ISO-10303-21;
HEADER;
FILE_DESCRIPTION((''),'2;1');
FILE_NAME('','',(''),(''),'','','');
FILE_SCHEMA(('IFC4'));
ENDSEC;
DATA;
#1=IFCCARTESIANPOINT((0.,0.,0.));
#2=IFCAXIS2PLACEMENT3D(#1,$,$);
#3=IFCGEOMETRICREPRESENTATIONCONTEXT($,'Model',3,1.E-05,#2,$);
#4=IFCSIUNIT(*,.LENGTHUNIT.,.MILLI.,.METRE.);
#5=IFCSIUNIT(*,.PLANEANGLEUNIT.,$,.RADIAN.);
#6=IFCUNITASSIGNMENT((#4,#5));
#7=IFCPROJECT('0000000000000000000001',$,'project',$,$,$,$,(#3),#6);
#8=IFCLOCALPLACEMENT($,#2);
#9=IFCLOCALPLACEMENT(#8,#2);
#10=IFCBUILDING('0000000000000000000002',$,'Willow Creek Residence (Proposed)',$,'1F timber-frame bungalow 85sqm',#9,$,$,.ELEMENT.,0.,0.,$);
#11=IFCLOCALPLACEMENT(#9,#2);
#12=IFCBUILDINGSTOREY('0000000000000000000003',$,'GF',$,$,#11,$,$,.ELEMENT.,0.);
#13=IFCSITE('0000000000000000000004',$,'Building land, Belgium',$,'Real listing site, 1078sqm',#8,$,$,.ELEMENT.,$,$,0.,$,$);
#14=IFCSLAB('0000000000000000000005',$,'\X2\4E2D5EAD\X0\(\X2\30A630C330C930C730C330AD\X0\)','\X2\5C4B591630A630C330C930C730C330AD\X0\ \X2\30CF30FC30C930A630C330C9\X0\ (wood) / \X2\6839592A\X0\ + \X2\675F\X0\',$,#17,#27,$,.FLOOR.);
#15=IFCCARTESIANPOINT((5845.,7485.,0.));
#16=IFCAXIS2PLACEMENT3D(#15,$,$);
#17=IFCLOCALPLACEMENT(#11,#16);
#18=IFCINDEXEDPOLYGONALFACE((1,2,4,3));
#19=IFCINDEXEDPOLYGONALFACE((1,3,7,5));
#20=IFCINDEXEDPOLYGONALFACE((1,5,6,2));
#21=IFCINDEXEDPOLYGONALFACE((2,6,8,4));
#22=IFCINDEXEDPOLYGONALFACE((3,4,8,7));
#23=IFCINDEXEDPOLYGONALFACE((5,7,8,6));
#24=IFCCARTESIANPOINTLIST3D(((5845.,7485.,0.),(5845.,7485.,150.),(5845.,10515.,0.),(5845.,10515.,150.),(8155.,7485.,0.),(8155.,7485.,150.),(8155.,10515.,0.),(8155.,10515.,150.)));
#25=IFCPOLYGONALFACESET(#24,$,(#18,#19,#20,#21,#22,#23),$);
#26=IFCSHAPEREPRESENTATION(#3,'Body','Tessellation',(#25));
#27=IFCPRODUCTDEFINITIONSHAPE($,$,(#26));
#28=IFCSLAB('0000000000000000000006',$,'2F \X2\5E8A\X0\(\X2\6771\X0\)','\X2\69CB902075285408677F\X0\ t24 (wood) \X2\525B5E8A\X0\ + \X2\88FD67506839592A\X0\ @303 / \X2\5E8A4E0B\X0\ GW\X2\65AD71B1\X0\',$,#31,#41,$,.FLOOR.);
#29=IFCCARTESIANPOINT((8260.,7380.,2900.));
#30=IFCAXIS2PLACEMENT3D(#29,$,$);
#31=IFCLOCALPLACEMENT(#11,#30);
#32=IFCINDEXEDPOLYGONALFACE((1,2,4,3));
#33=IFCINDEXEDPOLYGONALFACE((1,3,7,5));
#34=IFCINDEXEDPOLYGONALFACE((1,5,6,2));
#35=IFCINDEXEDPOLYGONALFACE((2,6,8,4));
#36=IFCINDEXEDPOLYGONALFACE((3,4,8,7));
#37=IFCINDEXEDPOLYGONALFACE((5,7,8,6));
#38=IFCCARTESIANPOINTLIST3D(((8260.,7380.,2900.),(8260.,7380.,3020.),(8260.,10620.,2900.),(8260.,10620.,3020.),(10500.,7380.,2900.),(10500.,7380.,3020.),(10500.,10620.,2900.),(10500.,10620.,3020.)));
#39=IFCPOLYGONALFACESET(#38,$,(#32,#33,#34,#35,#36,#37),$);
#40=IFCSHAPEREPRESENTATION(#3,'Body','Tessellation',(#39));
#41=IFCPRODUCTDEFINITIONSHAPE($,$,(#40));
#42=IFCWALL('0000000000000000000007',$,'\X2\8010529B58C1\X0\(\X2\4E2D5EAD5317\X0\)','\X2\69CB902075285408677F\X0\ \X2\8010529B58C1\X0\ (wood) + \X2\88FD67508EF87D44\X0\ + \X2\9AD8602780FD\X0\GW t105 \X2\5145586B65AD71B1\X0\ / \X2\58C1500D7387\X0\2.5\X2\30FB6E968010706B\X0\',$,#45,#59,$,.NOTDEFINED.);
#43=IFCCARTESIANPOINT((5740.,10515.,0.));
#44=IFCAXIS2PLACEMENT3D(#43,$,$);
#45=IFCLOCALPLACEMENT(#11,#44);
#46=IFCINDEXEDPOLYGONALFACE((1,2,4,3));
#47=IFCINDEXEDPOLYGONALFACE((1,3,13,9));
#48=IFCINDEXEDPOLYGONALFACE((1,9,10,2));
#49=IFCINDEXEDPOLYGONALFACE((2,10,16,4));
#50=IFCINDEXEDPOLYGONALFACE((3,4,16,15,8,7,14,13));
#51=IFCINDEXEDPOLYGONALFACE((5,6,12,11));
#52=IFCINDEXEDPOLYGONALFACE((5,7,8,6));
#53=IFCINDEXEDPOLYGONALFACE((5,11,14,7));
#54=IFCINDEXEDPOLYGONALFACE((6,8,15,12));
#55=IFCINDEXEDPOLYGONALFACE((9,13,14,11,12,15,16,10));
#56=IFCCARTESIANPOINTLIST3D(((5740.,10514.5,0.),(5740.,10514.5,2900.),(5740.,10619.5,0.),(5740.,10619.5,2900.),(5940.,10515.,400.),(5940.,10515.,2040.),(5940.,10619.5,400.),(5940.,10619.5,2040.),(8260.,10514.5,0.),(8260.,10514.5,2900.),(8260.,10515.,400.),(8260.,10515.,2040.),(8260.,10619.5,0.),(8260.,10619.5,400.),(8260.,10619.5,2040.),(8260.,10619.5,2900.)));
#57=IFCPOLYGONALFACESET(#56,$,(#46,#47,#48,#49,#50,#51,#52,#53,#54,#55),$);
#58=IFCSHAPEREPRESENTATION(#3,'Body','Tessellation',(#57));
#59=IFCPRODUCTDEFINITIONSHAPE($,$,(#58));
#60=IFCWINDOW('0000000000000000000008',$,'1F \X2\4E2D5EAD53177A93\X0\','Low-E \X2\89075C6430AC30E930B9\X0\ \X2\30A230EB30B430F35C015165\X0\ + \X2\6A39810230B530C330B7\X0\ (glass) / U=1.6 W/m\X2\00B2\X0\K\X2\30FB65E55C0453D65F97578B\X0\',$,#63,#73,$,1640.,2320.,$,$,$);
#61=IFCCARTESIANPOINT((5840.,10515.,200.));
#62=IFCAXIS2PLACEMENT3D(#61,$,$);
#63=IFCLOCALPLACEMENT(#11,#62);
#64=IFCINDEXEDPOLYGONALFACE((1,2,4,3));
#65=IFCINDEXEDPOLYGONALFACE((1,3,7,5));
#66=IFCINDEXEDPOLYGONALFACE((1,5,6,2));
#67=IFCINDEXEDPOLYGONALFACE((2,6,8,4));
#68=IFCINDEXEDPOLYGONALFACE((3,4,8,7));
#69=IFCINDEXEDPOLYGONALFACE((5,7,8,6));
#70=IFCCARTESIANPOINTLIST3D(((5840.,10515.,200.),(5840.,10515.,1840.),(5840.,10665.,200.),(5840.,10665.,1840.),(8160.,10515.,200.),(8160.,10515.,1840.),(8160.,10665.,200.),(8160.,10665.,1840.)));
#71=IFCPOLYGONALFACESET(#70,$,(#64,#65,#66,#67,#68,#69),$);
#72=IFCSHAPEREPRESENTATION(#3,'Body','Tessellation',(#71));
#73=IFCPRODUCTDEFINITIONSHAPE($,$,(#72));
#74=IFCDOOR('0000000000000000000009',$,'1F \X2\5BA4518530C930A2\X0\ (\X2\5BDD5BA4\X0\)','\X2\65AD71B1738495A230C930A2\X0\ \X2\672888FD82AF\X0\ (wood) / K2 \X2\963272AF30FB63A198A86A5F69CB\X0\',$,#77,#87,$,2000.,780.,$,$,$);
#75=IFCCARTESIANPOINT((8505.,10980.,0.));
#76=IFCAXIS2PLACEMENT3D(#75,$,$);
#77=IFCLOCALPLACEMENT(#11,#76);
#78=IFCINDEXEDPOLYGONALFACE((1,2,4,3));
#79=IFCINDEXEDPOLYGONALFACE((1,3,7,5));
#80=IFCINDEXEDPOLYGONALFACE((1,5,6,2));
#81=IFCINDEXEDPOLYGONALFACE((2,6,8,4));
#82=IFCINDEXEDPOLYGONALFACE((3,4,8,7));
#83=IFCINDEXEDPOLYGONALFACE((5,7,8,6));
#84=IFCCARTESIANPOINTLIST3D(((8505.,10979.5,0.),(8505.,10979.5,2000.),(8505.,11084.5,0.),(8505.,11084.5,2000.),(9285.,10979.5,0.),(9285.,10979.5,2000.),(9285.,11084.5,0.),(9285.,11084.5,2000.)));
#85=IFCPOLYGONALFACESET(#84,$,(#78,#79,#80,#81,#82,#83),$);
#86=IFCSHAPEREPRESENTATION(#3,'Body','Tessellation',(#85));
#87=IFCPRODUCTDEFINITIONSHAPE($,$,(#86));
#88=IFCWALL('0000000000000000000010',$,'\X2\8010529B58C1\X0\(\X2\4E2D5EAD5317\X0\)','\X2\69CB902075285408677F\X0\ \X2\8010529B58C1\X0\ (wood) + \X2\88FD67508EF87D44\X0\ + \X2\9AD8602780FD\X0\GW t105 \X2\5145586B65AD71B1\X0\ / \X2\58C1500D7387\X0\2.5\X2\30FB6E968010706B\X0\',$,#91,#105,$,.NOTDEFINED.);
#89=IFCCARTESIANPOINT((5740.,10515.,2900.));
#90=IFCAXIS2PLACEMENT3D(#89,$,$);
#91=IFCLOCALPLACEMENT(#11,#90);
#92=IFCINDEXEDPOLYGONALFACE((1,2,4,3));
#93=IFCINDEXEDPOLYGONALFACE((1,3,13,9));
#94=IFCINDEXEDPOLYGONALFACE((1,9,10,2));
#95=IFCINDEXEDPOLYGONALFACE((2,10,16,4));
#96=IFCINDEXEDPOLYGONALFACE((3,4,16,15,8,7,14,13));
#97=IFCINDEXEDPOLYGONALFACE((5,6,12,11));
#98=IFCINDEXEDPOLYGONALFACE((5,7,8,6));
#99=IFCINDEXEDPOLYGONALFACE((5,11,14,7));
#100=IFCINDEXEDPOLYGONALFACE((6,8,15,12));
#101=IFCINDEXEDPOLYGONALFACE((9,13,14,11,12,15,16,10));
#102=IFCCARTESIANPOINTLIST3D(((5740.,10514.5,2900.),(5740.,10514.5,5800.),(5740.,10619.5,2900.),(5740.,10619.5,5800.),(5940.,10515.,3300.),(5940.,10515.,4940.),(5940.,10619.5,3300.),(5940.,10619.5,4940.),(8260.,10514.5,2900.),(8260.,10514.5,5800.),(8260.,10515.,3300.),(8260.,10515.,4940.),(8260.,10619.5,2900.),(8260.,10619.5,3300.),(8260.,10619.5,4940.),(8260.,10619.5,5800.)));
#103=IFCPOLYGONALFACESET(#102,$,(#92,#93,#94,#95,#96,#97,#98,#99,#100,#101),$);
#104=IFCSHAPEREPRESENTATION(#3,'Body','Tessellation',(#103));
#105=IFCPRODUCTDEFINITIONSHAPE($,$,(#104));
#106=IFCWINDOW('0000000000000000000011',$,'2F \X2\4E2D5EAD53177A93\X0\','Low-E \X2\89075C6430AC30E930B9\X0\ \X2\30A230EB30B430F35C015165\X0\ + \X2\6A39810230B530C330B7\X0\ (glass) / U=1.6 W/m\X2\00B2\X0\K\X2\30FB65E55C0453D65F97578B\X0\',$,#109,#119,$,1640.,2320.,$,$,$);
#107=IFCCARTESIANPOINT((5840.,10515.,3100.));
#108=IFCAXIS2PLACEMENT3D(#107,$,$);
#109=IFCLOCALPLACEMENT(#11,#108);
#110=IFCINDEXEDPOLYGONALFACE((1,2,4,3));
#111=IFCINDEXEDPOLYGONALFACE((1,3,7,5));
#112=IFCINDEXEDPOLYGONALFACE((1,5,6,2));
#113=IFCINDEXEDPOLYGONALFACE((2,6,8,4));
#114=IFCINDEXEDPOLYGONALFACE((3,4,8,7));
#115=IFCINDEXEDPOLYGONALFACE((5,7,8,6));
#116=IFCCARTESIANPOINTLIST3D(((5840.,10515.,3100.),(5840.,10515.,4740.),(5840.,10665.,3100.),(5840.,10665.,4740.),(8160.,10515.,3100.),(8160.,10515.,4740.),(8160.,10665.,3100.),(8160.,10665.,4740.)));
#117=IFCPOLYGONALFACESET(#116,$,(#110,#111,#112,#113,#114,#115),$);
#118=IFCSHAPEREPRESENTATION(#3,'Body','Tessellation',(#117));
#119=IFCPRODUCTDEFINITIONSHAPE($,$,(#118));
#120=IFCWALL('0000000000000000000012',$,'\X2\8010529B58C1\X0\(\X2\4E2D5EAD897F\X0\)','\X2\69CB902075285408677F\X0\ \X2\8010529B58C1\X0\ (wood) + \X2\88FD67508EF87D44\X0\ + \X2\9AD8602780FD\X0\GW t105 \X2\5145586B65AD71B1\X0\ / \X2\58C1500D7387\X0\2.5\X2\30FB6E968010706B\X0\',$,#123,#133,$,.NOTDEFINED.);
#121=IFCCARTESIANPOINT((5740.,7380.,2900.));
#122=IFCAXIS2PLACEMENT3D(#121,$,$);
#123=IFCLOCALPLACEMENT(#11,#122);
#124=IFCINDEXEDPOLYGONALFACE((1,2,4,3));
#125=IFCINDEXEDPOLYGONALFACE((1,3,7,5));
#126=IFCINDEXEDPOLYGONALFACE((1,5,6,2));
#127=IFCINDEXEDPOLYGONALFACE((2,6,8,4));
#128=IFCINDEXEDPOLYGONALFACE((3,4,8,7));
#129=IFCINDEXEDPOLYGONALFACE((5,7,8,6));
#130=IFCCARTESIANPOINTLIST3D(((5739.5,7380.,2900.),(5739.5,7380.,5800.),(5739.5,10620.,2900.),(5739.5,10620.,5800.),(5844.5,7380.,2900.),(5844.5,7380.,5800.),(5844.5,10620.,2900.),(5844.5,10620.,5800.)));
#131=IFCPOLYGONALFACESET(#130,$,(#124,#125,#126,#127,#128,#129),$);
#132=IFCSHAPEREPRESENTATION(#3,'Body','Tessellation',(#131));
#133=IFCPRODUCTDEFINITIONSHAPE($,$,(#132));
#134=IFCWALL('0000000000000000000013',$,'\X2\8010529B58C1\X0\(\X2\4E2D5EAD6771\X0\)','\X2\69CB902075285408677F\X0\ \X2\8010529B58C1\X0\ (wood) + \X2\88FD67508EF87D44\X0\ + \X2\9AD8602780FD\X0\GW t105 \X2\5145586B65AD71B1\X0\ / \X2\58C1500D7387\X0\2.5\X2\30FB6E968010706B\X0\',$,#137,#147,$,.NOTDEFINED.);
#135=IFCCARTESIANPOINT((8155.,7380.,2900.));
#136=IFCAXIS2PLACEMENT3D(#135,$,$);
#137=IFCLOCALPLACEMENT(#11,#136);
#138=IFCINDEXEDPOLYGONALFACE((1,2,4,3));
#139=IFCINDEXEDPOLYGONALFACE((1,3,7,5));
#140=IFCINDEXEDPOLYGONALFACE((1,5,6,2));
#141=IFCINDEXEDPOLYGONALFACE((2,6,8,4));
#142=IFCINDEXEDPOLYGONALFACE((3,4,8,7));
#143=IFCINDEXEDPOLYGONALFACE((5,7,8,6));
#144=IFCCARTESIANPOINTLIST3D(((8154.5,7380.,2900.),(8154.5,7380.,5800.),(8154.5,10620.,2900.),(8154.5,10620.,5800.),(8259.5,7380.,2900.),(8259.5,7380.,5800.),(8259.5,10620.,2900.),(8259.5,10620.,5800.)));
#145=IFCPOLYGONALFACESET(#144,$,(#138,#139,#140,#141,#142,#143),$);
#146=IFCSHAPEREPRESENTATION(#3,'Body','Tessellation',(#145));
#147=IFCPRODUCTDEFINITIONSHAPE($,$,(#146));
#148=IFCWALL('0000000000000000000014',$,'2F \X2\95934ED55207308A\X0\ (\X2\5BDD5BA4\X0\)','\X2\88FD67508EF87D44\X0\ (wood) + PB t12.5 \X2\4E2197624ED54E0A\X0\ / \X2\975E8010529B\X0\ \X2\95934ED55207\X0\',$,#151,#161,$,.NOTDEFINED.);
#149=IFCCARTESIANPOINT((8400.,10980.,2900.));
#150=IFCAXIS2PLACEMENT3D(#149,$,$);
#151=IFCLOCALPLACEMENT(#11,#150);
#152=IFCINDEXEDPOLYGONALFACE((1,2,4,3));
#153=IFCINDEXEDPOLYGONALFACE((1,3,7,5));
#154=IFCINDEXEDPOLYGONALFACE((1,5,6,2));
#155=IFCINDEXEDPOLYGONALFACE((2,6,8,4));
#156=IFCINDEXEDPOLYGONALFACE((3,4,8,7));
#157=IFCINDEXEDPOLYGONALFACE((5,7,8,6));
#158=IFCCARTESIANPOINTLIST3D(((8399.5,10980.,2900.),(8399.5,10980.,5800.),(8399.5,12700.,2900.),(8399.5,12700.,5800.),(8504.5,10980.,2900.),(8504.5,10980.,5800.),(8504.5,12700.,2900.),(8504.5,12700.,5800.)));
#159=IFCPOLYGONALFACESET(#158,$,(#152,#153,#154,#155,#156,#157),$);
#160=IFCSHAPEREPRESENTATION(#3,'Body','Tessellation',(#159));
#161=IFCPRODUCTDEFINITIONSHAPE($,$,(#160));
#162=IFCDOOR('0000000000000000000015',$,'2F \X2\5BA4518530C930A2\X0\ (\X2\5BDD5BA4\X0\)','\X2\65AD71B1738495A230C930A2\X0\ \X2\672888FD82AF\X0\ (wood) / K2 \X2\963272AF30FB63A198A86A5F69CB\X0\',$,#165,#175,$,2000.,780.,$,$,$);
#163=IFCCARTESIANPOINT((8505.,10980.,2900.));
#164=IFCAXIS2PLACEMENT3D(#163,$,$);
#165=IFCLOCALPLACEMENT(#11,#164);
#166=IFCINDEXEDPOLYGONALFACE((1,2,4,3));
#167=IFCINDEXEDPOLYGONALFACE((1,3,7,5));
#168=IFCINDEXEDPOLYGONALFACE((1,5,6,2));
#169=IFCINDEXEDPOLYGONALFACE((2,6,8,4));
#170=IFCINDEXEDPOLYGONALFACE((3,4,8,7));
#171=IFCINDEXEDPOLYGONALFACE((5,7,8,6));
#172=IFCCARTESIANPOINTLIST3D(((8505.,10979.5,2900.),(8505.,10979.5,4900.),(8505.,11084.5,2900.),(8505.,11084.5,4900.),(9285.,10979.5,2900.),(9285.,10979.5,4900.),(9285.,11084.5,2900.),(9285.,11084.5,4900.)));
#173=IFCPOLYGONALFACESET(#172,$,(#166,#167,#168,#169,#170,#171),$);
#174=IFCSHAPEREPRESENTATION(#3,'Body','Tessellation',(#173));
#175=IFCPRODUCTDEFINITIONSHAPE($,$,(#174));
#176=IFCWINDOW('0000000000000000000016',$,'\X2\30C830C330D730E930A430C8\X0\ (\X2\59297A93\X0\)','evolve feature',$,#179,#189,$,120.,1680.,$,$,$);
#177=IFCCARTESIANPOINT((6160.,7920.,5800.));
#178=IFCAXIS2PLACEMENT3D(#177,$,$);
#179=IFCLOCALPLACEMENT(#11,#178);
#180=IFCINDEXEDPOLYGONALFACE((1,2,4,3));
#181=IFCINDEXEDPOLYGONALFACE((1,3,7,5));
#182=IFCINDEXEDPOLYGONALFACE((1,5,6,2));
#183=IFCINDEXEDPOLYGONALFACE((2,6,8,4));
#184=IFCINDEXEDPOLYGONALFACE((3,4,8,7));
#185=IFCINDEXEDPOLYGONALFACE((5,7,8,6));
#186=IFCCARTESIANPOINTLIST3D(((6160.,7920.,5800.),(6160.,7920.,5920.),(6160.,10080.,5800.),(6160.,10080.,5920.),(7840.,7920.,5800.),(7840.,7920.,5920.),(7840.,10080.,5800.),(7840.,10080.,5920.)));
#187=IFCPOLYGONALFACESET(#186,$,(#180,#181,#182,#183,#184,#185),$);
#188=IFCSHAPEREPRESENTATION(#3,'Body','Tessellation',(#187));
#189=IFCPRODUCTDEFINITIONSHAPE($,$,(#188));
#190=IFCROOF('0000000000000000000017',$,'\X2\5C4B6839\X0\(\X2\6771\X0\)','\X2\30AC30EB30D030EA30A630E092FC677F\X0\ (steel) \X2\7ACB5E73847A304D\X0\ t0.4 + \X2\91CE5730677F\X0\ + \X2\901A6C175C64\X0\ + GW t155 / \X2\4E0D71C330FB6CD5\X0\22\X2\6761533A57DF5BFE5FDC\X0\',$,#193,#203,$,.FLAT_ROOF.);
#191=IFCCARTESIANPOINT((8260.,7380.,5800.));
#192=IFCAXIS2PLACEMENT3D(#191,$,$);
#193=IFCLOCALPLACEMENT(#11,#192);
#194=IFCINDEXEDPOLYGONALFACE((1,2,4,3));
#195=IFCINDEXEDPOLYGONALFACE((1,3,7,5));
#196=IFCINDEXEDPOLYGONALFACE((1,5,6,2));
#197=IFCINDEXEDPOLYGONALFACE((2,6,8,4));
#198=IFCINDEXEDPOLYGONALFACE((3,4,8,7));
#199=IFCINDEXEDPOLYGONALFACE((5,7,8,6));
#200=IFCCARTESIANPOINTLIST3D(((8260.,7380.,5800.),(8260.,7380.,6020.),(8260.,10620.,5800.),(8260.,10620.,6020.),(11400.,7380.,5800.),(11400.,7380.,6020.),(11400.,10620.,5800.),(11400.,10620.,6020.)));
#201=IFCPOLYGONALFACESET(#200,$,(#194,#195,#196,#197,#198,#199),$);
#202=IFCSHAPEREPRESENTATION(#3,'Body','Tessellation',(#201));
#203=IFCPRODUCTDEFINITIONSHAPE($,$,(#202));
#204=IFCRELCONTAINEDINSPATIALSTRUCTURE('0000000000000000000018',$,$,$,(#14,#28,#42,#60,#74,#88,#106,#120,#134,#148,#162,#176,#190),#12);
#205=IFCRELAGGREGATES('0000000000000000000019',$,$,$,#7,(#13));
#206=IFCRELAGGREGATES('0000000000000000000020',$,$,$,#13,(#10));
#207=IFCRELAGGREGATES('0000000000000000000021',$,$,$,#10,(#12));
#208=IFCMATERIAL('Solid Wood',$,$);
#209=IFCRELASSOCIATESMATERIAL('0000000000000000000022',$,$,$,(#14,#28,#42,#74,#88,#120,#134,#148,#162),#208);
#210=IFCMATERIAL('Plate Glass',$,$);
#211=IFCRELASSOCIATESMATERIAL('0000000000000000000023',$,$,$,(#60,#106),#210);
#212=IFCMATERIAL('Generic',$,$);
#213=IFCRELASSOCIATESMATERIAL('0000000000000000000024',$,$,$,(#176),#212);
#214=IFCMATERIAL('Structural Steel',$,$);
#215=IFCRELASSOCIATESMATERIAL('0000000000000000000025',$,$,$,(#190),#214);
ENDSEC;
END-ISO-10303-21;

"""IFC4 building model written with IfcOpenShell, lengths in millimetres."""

from ifc_helpers import new_model, si_unit, frame, frame_2d, origin, place, context, project, spatial, rectangle, extrude, material, element, fill, save


model = new_model("IFC4")

# Units and contexts
model_context = context("Model", 3, precision=1e-05, world=origin())
ifc_project = project(units=[si_unit("LENGTHUNIT", "METRE", prefix="MILLI"), si_unit("PLANEANGLEUNIT", "RADIAN")], contexts=[model_context])

# Site, building, storey
site_placement = place(None, origin())
site = spatial("IfcSite", under=ifc_project, at=site_placement, Name="Building land, Belgium", ObjectType="Real listing site, 1078sqm", CompositionType="ELEMENT", RefElevation=0.0)
building_placement = place(site_placement, origin())
building = spatial("IfcBuilding", under=site, at=building_placement, Name="Willow Creek Residence (Proposed)", ObjectType="1F timber-frame bungalow 85sqm", CompositionType="ELEMENT", ElevationOfRefHeight=0.0, ElevationOfTerrain=0.0)
storey_placement = place(building_placement, origin())
storey = spatial("IfcBuildingStorey", under=building, at=storey_placement, Name="GF", CompositionType="ELEMENT", Elevation=0.0)

# Slabs
ifc_material_1 = material(Name="Solid Wood")
slab_1_placement = place(storey_placement, frame((5845.0, 7485.0, 0.0)))
element("IfcSlab", 1, at=slab_1_placement, inside=storey, material=ifc_material_1, Name="中庭(ウッドデッキ)", Description="屋外ウッドデッキ ハードウッド (wood) / 根太 + 束", PredefinedType="FLOOR", context=model_context, shape_type="SweptSolid", body=[
    extrude(rectangle(XDim=2310.0, YDim=3030.0, at=frame_2d((1155.0, 1515.0))), frame((5845.0, 7485.0, 0.0)), (0.0, 0.0, 1.0), 150.0),
])
slab_2_placement = place(storey_placement, frame((8260.0, 7380.0, 2900.0)))
element("IfcSlab", 2, at=slab_2_placement, inside=storey, material=ifc_material_1, Name="2F 床(東)", Description="構造用合板 t24 (wood) 剛床 + 製材根太 @303 / 床下 GW断熱", PredefinedType="FLOOR", context=model_context, shape_type="SweptSolid", body=[
    extrude(rectangle(XDim=2240.0, YDim=3240.0, at=frame_2d((1120.0, 1620.0))), frame((8260.0, 7380.0, 2900.0)), (0.0, 0.0, 1.0), 120.0),
])

# Wall, opening, window
wall_1_placement = place(storey_placement, frame((5740.0, 10515.0, 0.0)))
wall_1 = element("IfcWall", 3, at=wall_1_placement, inside=storey, material=ifc_material_1, Name="耐力壁(中庭北)", Description="構造用合板 耐力壁 (wood) + 製材軸組 + 高性能GW t105 充填断熱 / 壁倍率2.5・準耐火", PredefinedType="NOTDEFINED", context=model_context, shape_type="SweptSolid", body=[
    extrude(rectangle(XDim=2520.0, YDim=105.0, at=frame_2d((1260.0, 52.0))), frame((5740.0, 10515.0, 0.0)), (0.0, 0.0, 1.0), 2900.0),
])
opening_1_placement = place(storey_placement, frame((5840.0, 10515.0, 200.0)))
opening_1 = element("IfcOpeningElement", 4, at=opening_1_placement, cuts=wall_1, PredefinedType="NOTDEFINED", context=model_context, shape_type="SweptSolid", body=[
    extrude(rectangle(XDim=2320.0, YDim=150.0, at=frame_2d((1160.0, 75.0))), frame((5840.0, 10515.0, 200.0)), (0.0, 0.0, 1.0), 1640.0),
])
ifc_material_2 = material(Name="Plate Glass")
window_1_placement = place(storey_placement, frame((5840.0, 10515.0, 200.0)))
window_1 = element("IfcWindow", 5, at=window_1_placement, inside=storey, material=ifc_material_2, Name="1F 中庭北窓", Description="Low-E 複層ガラス アルゴン封入 + 樹脂サッシ (glass) / U=1.6 W/m²K・日射取得型", OverallHeight=1640.0, OverallWidth=2320.0, context=model_context, shape_type="SweptSolid", body=[
    extrude(rectangle(XDim=2320.0, YDim=150.0, at=frame_2d((1160.0, 75.0))), frame((5840.0, 10515.0, 200.0)), (0.0, 0.0, 1.0), 1640.0),
])
fill(opening_1, window_1)

# Door
door_1_placement = place(storey_placement, frame((8505.0, 10980.0, 0.0)))
element("IfcDoor", 6, at=door_1_placement, inside=storey, material=ifc_material_1, Name="1F 室内ドア (寝室)", Description="断熱玄関ドア 木製芯 (wood) / K2 防犯・採風機構", OverallHeight=2000.0, OverallWidth=780.0, context=model_context, shape_type="SweptSolid", body=[
    extrude(rectangle(XDim=780.0, YDim=105.0, at=frame_2d((390.0, 52.0))), frame((8505.0, 10980.0, 0.0)), (0.0, 0.0, 1.0), 2000.0),
])

# Wall, opening, window
wall_2_placement = place(storey_placement, frame((5740.0, 10515.0, 2900.0)))
wall_2 = element("IfcWall", 7, at=wall_2_placement, inside=storey, material=ifc_material_1, Name="耐力壁(中庭北)", Description="構造用合板 耐力壁 (wood) + 製材軸組 + 高性能GW t105 充填断熱 / 壁倍率2.5・準耐火", PredefinedType="NOTDEFINED", context=model_context, shape_type="SweptSolid", body=[
    extrude(rectangle(XDim=2520.0, YDim=105.0, at=frame_2d((1260.0, 52.0))), frame((5740.0, 10515.0, 2900.0)), (0.0, 0.0, 1.0), 2900.0),
])
opening_2_placement = place(storey_placement, frame((5840.0, 10515.0, 3100.0)))
opening_2 = element("IfcOpeningElement", 8, at=opening_2_placement, cuts=wall_2, PredefinedType="NOTDEFINED", context=model_context, shape_type="SweptSolid", body=[
    extrude(rectangle(XDim=2320.0, YDim=150.0, at=frame_2d((1160.0, 75.0))), frame((5840.0, 10515.0, 3100.0)), (0.0, 0.0, 1.0), 1640.0),
])
window_2_placement = place(storey_placement, frame((5840.0, 10515.0, 3100.0)))
window_2 = element("IfcWindow", 9, at=window_2_placement, inside=storey, material=ifc_material_2, Name="2F 中庭北窓", Description="Low-E 複層ガラス アルゴン封入 + 樹脂サッシ (glass) / U=1.6 W/m²K・日射取得型", OverallHeight=1640.0, OverallWidth=2320.0, context=model_context, shape_type="SweptSolid", body=[
    extrude(rectangle(XDim=2320.0, YDim=150.0, at=frame_2d((1160.0, 75.0))), frame((5840.0, 10515.0, 3100.0)), (0.0, 0.0, 1.0), 1640.0),
])
fill(opening_2, window_2)

# Walls
wall_3_placement = place(storey_placement, frame((5740.0, 7380.0, 2900.0)))
element("IfcWall", 10, at=wall_3_placement, inside=storey, material=ifc_material_1, Name="耐力壁(中庭西)", Description="構造用合板 耐力壁 (wood) + 製材軸組 + 高性能GW t105 充填断熱 / 壁倍率2.5・準耐火", PredefinedType="NOTDEFINED", context=model_context, shape_type="SweptSolid", body=[
    extrude(rectangle(XDim=105.0, YDim=3240.0, at=frame_2d((52.0, 1620.0))), frame((5740.0, 7380.0, 2900.0)), (0.0, 0.0, 1.0), 2900.0),
])
wall_4_placement = place(storey_placement, frame((8155.0, 7380.0, 2900.0)))
element("IfcWall", 11, at=wall_4_placement, inside=storey, material=ifc_material_1, Name="耐力壁(中庭東)", Description="構造用合板 耐力壁 (wood) + 製材軸組 + 高性能GW t105 充填断熱 / 壁倍率2.5・準耐火", PredefinedType="NOTDEFINED", context=model_context, shape_type="SweptSolid", body=[
    extrude(rectangle(XDim=105.0, YDim=3240.0, at=frame_2d((52.0, 1620.0))), frame((8155.0, 7380.0, 2900.0)), (0.0, 0.0, 1.0), 2900.0),
])
wall_5_placement = place(storey_placement, frame((8400.0, 10980.0, 2900.0)))
element("IfcWall", 12, at=wall_5_placement, inside=storey, material=ifc_material_1, Name="2F 間仕切り (寝室)", Description="製材軸組 (wood) + PB t12.5 両面仕上 / 非耐力 間仕切", PredefinedType="NOTDEFINED", context=model_context, shape_type="SweptSolid", body=[
    extrude(rectangle(XDim=105.0, YDim=1720.0, at=frame_2d((52.0, 860.0))), frame((8400.0, 10980.0, 2900.0)), (0.0, 0.0, 1.0), 2900.0),
])

# Door
door_2_placement = place(storey_placement, frame((8505.0, 10980.0, 2900.0)))
element("IfcDoor", 13, at=door_2_placement, inside=storey, material=ifc_material_1, Name="2F 室内ドア (寝室)", Description="断熱玄関ドア 木製芯 (wood) / K2 防犯・採風機構", OverallHeight=2000.0, OverallWidth=780.0, context=model_context, shape_type="SweptSolid", body=[
    extrude(rectangle(XDim=780.0, YDim=105.0, at=frame_2d((390.0, 52.0))), frame((8505.0, 10980.0, 2900.0)), (0.0, 0.0, 1.0), 2000.0),
])

# Window
ifc_material_3 = material(Name="Generic")
window_3_placement = place(storey_placement, frame((6160.0, 7920.0, 5800.0)))
element("IfcWindow", 14, at=window_3_placement, inside=storey, material=ifc_material_3, Name="トップライト (天窓)", Description="evolve feature", OverallHeight=120.0, OverallWidth=1680.0, context=model_context, shape_type="SweptSolid", body=[
    extrude(rectangle(XDim=1680.0, YDim=2160.0, at=frame_2d((840.0, 1080.0))), frame((6160.0, 7920.0, 5800.0)), (0.0, 0.0, 1.0), 120.0),
])

# Roof
ifc_material_4 = material(Name="Structural Steel")
roof_placement = place(storey_placement, frame((8260.0, 7380.0, 5800.0)))
element("IfcRoof", 15, at=roof_placement, inside=storey, material=ifc_material_4, Name="屋根(東)", Description="ガルバリウム鋼板 (steel) 立平葺き t0.4 + 野地板 + 通気層 + GW t155 / 不燃・法22条区域対応", PredefinedType="FLAT_ROOF", context=model_context, shape_type="SweptSolid", body=[
    extrude(rectangle(XDim=3140.0, YDim=3240.0, at=frame_2d((1570.0, 1620.0))), frame((8260.0, 7380.0, 5800.0)), (0.0, 0.0, 1.0), 220.0),
])

save(model, "model.ifc")
